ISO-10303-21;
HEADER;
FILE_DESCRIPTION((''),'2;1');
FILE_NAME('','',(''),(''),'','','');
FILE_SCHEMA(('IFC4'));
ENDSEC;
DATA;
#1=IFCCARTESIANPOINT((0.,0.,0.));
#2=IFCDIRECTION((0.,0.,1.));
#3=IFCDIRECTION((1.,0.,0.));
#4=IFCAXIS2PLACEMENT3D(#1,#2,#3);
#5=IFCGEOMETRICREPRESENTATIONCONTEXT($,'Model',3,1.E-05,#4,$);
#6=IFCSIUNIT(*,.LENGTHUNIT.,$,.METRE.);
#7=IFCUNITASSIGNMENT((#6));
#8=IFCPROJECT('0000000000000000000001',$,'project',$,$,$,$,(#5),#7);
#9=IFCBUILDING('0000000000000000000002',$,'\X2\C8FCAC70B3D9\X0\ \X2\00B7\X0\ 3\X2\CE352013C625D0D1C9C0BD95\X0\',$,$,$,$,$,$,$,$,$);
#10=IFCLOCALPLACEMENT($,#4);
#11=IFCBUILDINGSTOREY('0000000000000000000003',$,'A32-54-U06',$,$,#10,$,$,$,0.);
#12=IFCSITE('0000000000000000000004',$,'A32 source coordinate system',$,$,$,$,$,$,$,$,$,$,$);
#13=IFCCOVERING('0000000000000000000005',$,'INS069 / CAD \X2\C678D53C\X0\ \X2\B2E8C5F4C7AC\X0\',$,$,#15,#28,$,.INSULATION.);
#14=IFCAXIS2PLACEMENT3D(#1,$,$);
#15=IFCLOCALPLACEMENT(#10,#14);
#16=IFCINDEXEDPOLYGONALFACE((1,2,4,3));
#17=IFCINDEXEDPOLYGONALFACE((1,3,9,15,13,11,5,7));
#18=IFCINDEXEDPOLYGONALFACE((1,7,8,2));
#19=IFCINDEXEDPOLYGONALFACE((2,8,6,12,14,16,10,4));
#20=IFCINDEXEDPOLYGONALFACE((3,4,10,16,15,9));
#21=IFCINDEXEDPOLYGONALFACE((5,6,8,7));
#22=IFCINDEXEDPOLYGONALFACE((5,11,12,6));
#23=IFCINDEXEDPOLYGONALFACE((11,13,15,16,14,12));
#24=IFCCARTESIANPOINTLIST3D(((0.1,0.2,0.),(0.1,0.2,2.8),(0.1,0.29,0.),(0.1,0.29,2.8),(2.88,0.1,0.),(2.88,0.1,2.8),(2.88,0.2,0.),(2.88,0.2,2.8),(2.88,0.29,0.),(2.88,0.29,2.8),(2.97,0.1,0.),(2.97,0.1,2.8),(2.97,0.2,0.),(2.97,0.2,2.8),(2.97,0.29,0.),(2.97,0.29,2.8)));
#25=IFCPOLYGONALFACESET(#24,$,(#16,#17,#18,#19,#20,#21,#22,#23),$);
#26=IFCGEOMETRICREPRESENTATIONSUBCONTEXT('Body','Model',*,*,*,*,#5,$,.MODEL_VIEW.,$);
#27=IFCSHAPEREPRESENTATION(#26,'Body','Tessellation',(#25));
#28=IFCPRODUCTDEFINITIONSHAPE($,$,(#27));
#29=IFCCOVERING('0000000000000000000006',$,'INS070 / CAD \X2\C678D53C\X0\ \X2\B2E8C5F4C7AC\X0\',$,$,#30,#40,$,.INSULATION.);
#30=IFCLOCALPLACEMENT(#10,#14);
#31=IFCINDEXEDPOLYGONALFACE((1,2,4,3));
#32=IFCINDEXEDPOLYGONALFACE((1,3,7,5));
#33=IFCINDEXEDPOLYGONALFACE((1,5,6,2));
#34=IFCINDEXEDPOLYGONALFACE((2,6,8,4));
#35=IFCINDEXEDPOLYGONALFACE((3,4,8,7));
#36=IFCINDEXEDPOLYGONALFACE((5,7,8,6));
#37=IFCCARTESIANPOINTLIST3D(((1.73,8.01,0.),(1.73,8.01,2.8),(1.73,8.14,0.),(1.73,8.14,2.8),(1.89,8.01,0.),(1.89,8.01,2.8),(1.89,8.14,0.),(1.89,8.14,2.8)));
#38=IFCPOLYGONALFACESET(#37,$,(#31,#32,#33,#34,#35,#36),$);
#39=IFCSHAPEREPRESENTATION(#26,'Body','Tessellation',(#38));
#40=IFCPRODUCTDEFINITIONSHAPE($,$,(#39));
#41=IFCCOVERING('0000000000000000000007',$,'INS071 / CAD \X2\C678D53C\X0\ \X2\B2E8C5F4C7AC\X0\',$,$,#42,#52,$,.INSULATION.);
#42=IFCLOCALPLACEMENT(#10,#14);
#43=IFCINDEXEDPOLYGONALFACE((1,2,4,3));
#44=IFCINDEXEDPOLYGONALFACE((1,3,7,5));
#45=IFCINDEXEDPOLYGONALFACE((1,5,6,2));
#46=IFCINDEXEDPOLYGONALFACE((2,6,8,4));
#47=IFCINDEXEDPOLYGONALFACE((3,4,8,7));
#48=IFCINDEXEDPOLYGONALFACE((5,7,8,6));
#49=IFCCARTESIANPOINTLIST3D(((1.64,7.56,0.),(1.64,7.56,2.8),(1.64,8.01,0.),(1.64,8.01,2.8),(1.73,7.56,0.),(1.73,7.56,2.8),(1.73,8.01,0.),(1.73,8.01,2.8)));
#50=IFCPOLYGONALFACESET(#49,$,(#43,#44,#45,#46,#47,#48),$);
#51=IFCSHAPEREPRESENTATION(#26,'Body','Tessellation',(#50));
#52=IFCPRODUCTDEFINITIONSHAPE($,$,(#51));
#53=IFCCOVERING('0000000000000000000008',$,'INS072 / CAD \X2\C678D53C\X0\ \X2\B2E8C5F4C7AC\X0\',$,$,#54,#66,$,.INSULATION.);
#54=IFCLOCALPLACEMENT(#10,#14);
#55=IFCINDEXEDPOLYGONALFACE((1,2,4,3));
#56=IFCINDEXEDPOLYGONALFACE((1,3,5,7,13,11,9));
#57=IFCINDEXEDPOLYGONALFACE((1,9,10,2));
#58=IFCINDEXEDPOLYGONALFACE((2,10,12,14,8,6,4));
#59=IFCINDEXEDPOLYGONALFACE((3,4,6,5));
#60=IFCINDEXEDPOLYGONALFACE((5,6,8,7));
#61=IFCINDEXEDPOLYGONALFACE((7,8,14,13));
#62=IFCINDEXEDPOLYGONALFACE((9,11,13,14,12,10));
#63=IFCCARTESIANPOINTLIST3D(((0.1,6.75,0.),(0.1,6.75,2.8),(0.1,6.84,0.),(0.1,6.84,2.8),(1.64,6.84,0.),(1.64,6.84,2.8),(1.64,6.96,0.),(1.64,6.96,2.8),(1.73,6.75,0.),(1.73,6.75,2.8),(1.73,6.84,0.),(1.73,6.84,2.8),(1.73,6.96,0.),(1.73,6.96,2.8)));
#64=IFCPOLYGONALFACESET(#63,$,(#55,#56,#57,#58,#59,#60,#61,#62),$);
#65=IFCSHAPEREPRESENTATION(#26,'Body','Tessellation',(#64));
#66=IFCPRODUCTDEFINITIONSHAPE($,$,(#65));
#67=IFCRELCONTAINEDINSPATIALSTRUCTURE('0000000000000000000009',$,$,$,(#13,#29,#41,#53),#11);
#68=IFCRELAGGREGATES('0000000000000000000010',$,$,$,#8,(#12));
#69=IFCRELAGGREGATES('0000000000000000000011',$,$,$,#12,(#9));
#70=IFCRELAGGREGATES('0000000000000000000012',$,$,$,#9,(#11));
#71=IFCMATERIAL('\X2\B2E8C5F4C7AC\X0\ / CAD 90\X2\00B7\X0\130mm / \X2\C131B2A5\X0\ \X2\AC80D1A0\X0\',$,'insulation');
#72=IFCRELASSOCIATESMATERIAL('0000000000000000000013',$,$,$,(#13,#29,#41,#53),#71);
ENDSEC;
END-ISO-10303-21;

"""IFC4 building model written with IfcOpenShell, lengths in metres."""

from ifc_helpers import new_model, si_unit, origin, origin_with_axes, place, context, subcontext, project, spatial, polyline, outline, extrude, material, element, save


model = new_model("IFC4")

# Units and contexts
model_context = context("Model", 3, precision=1e-05, world=origin_with_axes())
body_context = subcontext(model_context, "Body", "Model", "MODEL_VIEW")
ifc_project = project(units=[si_unit("LENGTHUNIT", "METRE")], contexts=[model_context])

# Site, building, storey
storey_placement = place(None, origin_with_axes())
site = spatial("IfcSite", under=ifc_project, Name="A32 source coordinate system")
building = spatial("IfcBuilding", under=site, Name="주거동 · 3층–옥탑지붕")
storey = spatial("IfcBuildingStorey", under=building, at=storey_placement, Name="A32-54-U06", Elevation=0.0)

# Coverings
ifc_material = material(Name="단열재 / CAD 90·130mm / 성능 검토", Category="insulation")
covering_1_placement = place(storey_placement, origin_with_axes())
element("IfcCovering", 1, at=covering_1_placement, inside=storey, material=ifc_material, Name="INS069 / CAD 외피 단열재", PredefinedType="INSULATION", context=body_context, shape_type="SweptSolid", body=[
    extrude(outline(polyline([(2.97, 0.1), (2.88, 0.1), (2.88, 0.2), (0.1, 0.2), (0.1, 0.29), (2.88, 0.29), (2.97, 0.29), (2.97, 0.2), (2.97, 0.1)])), origin(), (0.0, 0.0, 1.0), 2.8),
])
covering_2_placement = place(storey_placement, origin_with_axes())
element("IfcCovering", 2, at=covering_2_placement, inside=storey, material=ifc_material, Name="INS070 / CAD 외피 단열재", PredefinedType="INSULATION", context=body_context, shape_type="SweptSolid", body=[
    extrude(outline(polyline([(1.73, 8.14), (1.89, 8.14), (1.89, 8.01), (1.73, 8.01), (1.73, 8.14)])), origin(), (0.0, 0.0, 1.0), 2.8),
])
covering_3_placement = place(storey_placement, origin_with_axes())
element("IfcCovering", 3, at=covering_3_placement, inside=storey, material=ifc_material, Name="INS071 / CAD 외피 단열재", PredefinedType="INSULATION", context=body_context, shape_type="SweptSolid", body=[
    extrude(outline(polyline([(1.73, 7.56), (1.64, 7.56), (1.64, 8.01), (1.73, 8.01), (1.73, 7.56)])), origin(), (0.0, 0.0, 1.0), 2.8),
])
covering_4_placement = place(storey_placement, origin_with_axes())
element("IfcCovering", 4, at=covering_4_placement, inside=storey, material=ifc_material, Name="INS072 / CAD 외피 단열재", PredefinedType="INSULATION", context=body_context, shape_type="SweptSolid", body=[
    extrude(outline(polyline([(1.64, 6.84), (1.64, 6.96), (1.73, 6.96), (1.73, 6.84), (1.73, 6.75), (0.1, 6.75), (0.1, 6.84), (1.64, 6.84)])), origin(), (0.0, 0.0, 1.0), 2.8),
])

save(model, "model.ifc")
